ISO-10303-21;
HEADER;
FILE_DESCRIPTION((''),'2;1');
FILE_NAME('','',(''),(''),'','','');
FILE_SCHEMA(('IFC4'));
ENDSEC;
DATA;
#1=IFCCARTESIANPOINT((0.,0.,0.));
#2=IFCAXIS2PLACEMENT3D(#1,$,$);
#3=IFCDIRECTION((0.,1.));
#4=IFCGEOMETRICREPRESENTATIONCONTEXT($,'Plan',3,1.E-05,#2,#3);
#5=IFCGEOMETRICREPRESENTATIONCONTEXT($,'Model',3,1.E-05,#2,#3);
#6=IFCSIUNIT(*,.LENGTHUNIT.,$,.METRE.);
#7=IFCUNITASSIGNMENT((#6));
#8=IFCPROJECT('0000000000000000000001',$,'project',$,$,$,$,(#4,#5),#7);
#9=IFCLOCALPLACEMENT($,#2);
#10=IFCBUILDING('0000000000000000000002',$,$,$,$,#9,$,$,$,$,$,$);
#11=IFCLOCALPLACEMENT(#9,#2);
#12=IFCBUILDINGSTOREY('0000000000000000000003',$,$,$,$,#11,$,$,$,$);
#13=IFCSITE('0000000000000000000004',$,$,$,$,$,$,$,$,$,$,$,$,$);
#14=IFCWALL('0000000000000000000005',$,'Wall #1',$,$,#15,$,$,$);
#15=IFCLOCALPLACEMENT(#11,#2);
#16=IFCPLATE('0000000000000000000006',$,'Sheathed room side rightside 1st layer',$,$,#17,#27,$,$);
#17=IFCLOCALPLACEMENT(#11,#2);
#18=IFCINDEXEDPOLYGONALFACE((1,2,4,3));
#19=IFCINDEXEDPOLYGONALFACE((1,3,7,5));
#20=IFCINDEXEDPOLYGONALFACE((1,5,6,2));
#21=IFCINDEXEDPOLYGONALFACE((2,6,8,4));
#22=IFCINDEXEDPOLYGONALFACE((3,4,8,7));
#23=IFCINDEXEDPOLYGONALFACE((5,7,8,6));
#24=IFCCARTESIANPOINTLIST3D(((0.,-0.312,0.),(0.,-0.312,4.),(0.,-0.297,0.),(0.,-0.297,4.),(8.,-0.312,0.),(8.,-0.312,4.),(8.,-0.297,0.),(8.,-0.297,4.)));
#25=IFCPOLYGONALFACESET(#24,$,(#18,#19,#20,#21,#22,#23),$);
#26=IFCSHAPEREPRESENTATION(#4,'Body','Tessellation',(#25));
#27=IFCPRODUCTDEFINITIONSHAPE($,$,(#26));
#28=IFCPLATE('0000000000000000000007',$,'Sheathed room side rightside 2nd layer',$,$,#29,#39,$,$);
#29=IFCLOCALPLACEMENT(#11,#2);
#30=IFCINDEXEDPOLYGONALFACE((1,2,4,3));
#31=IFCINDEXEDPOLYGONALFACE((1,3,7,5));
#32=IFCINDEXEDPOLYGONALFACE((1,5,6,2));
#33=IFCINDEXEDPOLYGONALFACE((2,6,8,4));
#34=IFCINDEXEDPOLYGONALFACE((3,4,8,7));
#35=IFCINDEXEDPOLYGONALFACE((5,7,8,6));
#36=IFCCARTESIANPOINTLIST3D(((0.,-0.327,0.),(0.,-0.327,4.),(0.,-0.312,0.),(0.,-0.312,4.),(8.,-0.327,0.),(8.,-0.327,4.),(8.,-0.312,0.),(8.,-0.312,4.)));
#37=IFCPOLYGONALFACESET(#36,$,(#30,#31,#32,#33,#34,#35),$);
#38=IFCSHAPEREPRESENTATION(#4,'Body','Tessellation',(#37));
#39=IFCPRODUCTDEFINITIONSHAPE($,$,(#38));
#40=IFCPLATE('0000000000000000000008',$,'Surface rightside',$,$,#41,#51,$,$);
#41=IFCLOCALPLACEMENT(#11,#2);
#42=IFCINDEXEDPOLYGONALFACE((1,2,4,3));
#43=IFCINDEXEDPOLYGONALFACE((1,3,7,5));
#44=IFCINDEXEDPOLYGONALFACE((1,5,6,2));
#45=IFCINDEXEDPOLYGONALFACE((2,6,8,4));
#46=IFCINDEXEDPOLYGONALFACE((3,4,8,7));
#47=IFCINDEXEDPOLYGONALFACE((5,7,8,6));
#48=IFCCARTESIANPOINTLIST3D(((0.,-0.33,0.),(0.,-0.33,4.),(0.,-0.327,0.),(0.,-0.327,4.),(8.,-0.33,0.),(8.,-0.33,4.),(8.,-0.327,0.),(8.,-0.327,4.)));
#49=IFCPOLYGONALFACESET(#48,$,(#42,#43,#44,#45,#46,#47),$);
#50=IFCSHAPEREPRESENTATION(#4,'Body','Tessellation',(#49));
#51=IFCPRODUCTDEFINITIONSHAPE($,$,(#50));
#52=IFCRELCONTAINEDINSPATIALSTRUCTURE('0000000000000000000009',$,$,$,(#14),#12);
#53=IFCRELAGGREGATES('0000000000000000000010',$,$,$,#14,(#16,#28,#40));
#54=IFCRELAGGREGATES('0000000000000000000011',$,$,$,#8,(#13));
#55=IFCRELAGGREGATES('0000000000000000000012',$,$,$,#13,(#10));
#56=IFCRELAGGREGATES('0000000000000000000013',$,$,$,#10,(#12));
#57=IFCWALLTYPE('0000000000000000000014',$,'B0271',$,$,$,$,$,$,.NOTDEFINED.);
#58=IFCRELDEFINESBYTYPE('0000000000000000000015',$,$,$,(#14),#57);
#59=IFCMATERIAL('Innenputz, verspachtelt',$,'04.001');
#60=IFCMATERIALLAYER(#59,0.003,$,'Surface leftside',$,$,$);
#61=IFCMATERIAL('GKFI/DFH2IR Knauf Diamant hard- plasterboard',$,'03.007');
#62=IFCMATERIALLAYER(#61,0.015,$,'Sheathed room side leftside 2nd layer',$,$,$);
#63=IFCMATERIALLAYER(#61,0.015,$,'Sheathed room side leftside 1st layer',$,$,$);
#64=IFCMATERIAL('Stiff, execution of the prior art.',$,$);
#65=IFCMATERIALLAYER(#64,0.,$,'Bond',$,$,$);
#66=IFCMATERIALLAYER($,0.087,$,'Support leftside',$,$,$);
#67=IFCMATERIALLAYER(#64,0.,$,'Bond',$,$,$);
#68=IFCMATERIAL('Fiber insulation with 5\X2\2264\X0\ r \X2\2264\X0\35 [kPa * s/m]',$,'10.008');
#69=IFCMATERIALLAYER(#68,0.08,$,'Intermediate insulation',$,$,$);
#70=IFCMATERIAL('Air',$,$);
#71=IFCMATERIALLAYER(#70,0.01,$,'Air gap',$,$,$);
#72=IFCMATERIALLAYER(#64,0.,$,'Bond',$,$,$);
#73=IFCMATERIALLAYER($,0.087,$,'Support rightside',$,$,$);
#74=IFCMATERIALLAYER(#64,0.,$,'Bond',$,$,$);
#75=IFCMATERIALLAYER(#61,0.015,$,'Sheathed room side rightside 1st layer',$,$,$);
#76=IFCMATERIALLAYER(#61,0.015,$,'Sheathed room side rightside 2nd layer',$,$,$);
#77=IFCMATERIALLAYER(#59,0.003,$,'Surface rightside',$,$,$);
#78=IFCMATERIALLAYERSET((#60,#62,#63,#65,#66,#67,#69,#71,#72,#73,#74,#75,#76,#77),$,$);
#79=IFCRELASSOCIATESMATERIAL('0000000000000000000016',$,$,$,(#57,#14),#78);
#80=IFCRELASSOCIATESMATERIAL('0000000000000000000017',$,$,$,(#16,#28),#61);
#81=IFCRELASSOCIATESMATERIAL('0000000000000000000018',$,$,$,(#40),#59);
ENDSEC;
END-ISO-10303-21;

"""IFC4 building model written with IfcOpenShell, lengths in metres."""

from ifc_helpers import new_model, si_unit, direction, frame, frame_2d, origin, place, context, project, spatial, rectangle, extrude, material, layer, layer_set, type_object, element, aggregate, save


model = new_model("IFC4")

# Units and contexts
plan_context = context("Plan", 3, precision=1e-05, world=origin(), true_north=direction((0.0, 1.0)))
model_context = context("Model", 3, precision=1e-05, world=origin(), true_north=direction((0.0, 1.0)))
ifc_project = project(units=[si_unit("LENGTHUNIT", "METRE")], contexts=[plan_context, model_context])

# Site, building, storey
site = spatial("IfcSite", under=ifc_project)
building_placement = place(None, origin())
building = spatial("IfcBuilding", under=site, at=building_placement)
storey_placement = place(building_placement, origin())
storey = spatial("IfcBuildingStorey", under=building, at=storey_placement)

# Wall, plates
ifc_material_1 = material(Name="Innenputz, verspachtelt", Category="04.001")
ifc_layer_1 = layer(ifc_material_1, 0.003, Name="Surface leftside")
ifc_material_2 = material(Name="GKFI/DFH2IR Knauf Diamant hard- plasterboard", Category="03.007")
ifc_layer_2 = layer(ifc_material_2, 0.015, Name="Sheathed room side leftside 2nd layer")
ifc_layer_3 = layer(ifc_material_2, 0.015, Name="Sheathed room side leftside 1st layer")
ifc_material_3 = material(Name="Stiff, execution of the prior art.")
ifc_layer_4 = layer(ifc_material_3, 0.0, Name="Bond")
ifc_layer_5 = layer(None, 0.087, Name="Support leftside")
ifc_layer_6 = layer(ifc_material_3, 0.0, Name="Bond")
ifc_material_4 = material(Name="Fiber insulation with 5≤ r ≤35 [kPa * s/m]", Category="10.008")
ifc_layer_7 = layer(ifc_material_4, 0.08, Name="Intermediate insulation")
ifc_material_5 = material(Name="Air")
ifc_layer_8 = layer(ifc_material_5, 0.01, Name="Air gap")
ifc_layer_9 = layer(ifc_material_3, 0.0, Name="Bond")
ifc_layer_10 = layer(None, 0.087, Name="Support rightside")
ifc_layer_11 = layer(ifc_material_3, 0.0, Name="Bond")
ifc_layer_12 = layer(ifc_material_2, 0.015, Name="Sheathed room side rightside 1st layer")
ifc_layer_13 = layer(ifc_material_2, 0.015, Name="Sheathed room side rightside 2nd layer")
ifc_layer_14 = layer(ifc_material_1, 0.003, Name="Surface rightside")
ifc_layer_set = layer_set([ifc_layer_1, ifc_layer_2, ifc_layer_3, ifc_layer_4, ifc_layer_5, ifc_layer_6, ifc_layer_7, ifc_layer_8, ifc_layer_9, ifc_layer_10, ifc_layer_11, ifc_layer_12, ifc_layer_13, ifc_layer_14])
wall_type = type_object("IfcWallType", Name="B0271", PredefinedType="NOTDEFINED", material=ifc_layer_set)
wall_placement = place(None, frame((0.0, 0.0, 0.0), z_axis=(0.0, -1.0, 0.0), x_axis=(1.0, 0.0, 0.0)))
wall = element("IfcWall", 1, at=wall_placement, inside=storey, type_object=wall_type, material=ifc_layer_set, Name="Wall #1")
plate_1_placement = place(wall_placement, origin())
plate_1 = element("IfcPlate", 2, at=plate_1_placement, material=ifc_material_2, Name="Sheathed room side rightside 1st layer", context=plan_context, shape_type="SweptSolid", body=[
    extrude(rectangle(XDim=8.0, YDim=4.0, at=frame_2d((4.0, 2.0), x_axis=(1.0, 0.0))), frame((0.0, 0.0, 0.297), z_axis=(0.0, 0.0, 1.0), x_axis=(1.0, 0.0, 0.0)), (0.0, 0.0, 1.0), 0.015),
])
plate_2_placement = place(wall_placement, origin())
plate_2 = element("IfcPlate", 3, at=plate_2_placement, material=ifc_material_2, Name="Sheathed room side rightside 2nd layer", context=plan_context, shape_type="SweptSolid", body=[
    extrude(rectangle(XDim=8.0, YDim=4.0, at=frame_2d((4.0, 2.0), x_axis=(1.0, 0.0))), frame((0.0, 0.0, 0.312), z_axis=(0.0, 0.0, 1.0), x_axis=(1.0, 0.0, 0.0)), (0.0, 0.0, 1.0), 0.015),
])
plate_3_placement = place(wall_placement, origin())
plate_3 = element("IfcPlate", 4, at=plate_3_placement, material=ifc_material_1, Name="Surface rightside", context=plan_context, shape_type="SweptSolid", body=[
    extrude(rectangle(XDim=8.0, YDim=4.0, at=frame_2d((4.0, 2.0), x_axis=(1.0, 0.0))), frame((0.0, 0.0, 0.327), z_axis=(0.0, 0.0, 1.0), x_axis=(1.0, 0.0, 0.0)), (0.0, 0.0, 1.0), 0.003),
])
aggregate(wall, [plate_1, plate_2, plate_3])

save(model, "model.ifc")
